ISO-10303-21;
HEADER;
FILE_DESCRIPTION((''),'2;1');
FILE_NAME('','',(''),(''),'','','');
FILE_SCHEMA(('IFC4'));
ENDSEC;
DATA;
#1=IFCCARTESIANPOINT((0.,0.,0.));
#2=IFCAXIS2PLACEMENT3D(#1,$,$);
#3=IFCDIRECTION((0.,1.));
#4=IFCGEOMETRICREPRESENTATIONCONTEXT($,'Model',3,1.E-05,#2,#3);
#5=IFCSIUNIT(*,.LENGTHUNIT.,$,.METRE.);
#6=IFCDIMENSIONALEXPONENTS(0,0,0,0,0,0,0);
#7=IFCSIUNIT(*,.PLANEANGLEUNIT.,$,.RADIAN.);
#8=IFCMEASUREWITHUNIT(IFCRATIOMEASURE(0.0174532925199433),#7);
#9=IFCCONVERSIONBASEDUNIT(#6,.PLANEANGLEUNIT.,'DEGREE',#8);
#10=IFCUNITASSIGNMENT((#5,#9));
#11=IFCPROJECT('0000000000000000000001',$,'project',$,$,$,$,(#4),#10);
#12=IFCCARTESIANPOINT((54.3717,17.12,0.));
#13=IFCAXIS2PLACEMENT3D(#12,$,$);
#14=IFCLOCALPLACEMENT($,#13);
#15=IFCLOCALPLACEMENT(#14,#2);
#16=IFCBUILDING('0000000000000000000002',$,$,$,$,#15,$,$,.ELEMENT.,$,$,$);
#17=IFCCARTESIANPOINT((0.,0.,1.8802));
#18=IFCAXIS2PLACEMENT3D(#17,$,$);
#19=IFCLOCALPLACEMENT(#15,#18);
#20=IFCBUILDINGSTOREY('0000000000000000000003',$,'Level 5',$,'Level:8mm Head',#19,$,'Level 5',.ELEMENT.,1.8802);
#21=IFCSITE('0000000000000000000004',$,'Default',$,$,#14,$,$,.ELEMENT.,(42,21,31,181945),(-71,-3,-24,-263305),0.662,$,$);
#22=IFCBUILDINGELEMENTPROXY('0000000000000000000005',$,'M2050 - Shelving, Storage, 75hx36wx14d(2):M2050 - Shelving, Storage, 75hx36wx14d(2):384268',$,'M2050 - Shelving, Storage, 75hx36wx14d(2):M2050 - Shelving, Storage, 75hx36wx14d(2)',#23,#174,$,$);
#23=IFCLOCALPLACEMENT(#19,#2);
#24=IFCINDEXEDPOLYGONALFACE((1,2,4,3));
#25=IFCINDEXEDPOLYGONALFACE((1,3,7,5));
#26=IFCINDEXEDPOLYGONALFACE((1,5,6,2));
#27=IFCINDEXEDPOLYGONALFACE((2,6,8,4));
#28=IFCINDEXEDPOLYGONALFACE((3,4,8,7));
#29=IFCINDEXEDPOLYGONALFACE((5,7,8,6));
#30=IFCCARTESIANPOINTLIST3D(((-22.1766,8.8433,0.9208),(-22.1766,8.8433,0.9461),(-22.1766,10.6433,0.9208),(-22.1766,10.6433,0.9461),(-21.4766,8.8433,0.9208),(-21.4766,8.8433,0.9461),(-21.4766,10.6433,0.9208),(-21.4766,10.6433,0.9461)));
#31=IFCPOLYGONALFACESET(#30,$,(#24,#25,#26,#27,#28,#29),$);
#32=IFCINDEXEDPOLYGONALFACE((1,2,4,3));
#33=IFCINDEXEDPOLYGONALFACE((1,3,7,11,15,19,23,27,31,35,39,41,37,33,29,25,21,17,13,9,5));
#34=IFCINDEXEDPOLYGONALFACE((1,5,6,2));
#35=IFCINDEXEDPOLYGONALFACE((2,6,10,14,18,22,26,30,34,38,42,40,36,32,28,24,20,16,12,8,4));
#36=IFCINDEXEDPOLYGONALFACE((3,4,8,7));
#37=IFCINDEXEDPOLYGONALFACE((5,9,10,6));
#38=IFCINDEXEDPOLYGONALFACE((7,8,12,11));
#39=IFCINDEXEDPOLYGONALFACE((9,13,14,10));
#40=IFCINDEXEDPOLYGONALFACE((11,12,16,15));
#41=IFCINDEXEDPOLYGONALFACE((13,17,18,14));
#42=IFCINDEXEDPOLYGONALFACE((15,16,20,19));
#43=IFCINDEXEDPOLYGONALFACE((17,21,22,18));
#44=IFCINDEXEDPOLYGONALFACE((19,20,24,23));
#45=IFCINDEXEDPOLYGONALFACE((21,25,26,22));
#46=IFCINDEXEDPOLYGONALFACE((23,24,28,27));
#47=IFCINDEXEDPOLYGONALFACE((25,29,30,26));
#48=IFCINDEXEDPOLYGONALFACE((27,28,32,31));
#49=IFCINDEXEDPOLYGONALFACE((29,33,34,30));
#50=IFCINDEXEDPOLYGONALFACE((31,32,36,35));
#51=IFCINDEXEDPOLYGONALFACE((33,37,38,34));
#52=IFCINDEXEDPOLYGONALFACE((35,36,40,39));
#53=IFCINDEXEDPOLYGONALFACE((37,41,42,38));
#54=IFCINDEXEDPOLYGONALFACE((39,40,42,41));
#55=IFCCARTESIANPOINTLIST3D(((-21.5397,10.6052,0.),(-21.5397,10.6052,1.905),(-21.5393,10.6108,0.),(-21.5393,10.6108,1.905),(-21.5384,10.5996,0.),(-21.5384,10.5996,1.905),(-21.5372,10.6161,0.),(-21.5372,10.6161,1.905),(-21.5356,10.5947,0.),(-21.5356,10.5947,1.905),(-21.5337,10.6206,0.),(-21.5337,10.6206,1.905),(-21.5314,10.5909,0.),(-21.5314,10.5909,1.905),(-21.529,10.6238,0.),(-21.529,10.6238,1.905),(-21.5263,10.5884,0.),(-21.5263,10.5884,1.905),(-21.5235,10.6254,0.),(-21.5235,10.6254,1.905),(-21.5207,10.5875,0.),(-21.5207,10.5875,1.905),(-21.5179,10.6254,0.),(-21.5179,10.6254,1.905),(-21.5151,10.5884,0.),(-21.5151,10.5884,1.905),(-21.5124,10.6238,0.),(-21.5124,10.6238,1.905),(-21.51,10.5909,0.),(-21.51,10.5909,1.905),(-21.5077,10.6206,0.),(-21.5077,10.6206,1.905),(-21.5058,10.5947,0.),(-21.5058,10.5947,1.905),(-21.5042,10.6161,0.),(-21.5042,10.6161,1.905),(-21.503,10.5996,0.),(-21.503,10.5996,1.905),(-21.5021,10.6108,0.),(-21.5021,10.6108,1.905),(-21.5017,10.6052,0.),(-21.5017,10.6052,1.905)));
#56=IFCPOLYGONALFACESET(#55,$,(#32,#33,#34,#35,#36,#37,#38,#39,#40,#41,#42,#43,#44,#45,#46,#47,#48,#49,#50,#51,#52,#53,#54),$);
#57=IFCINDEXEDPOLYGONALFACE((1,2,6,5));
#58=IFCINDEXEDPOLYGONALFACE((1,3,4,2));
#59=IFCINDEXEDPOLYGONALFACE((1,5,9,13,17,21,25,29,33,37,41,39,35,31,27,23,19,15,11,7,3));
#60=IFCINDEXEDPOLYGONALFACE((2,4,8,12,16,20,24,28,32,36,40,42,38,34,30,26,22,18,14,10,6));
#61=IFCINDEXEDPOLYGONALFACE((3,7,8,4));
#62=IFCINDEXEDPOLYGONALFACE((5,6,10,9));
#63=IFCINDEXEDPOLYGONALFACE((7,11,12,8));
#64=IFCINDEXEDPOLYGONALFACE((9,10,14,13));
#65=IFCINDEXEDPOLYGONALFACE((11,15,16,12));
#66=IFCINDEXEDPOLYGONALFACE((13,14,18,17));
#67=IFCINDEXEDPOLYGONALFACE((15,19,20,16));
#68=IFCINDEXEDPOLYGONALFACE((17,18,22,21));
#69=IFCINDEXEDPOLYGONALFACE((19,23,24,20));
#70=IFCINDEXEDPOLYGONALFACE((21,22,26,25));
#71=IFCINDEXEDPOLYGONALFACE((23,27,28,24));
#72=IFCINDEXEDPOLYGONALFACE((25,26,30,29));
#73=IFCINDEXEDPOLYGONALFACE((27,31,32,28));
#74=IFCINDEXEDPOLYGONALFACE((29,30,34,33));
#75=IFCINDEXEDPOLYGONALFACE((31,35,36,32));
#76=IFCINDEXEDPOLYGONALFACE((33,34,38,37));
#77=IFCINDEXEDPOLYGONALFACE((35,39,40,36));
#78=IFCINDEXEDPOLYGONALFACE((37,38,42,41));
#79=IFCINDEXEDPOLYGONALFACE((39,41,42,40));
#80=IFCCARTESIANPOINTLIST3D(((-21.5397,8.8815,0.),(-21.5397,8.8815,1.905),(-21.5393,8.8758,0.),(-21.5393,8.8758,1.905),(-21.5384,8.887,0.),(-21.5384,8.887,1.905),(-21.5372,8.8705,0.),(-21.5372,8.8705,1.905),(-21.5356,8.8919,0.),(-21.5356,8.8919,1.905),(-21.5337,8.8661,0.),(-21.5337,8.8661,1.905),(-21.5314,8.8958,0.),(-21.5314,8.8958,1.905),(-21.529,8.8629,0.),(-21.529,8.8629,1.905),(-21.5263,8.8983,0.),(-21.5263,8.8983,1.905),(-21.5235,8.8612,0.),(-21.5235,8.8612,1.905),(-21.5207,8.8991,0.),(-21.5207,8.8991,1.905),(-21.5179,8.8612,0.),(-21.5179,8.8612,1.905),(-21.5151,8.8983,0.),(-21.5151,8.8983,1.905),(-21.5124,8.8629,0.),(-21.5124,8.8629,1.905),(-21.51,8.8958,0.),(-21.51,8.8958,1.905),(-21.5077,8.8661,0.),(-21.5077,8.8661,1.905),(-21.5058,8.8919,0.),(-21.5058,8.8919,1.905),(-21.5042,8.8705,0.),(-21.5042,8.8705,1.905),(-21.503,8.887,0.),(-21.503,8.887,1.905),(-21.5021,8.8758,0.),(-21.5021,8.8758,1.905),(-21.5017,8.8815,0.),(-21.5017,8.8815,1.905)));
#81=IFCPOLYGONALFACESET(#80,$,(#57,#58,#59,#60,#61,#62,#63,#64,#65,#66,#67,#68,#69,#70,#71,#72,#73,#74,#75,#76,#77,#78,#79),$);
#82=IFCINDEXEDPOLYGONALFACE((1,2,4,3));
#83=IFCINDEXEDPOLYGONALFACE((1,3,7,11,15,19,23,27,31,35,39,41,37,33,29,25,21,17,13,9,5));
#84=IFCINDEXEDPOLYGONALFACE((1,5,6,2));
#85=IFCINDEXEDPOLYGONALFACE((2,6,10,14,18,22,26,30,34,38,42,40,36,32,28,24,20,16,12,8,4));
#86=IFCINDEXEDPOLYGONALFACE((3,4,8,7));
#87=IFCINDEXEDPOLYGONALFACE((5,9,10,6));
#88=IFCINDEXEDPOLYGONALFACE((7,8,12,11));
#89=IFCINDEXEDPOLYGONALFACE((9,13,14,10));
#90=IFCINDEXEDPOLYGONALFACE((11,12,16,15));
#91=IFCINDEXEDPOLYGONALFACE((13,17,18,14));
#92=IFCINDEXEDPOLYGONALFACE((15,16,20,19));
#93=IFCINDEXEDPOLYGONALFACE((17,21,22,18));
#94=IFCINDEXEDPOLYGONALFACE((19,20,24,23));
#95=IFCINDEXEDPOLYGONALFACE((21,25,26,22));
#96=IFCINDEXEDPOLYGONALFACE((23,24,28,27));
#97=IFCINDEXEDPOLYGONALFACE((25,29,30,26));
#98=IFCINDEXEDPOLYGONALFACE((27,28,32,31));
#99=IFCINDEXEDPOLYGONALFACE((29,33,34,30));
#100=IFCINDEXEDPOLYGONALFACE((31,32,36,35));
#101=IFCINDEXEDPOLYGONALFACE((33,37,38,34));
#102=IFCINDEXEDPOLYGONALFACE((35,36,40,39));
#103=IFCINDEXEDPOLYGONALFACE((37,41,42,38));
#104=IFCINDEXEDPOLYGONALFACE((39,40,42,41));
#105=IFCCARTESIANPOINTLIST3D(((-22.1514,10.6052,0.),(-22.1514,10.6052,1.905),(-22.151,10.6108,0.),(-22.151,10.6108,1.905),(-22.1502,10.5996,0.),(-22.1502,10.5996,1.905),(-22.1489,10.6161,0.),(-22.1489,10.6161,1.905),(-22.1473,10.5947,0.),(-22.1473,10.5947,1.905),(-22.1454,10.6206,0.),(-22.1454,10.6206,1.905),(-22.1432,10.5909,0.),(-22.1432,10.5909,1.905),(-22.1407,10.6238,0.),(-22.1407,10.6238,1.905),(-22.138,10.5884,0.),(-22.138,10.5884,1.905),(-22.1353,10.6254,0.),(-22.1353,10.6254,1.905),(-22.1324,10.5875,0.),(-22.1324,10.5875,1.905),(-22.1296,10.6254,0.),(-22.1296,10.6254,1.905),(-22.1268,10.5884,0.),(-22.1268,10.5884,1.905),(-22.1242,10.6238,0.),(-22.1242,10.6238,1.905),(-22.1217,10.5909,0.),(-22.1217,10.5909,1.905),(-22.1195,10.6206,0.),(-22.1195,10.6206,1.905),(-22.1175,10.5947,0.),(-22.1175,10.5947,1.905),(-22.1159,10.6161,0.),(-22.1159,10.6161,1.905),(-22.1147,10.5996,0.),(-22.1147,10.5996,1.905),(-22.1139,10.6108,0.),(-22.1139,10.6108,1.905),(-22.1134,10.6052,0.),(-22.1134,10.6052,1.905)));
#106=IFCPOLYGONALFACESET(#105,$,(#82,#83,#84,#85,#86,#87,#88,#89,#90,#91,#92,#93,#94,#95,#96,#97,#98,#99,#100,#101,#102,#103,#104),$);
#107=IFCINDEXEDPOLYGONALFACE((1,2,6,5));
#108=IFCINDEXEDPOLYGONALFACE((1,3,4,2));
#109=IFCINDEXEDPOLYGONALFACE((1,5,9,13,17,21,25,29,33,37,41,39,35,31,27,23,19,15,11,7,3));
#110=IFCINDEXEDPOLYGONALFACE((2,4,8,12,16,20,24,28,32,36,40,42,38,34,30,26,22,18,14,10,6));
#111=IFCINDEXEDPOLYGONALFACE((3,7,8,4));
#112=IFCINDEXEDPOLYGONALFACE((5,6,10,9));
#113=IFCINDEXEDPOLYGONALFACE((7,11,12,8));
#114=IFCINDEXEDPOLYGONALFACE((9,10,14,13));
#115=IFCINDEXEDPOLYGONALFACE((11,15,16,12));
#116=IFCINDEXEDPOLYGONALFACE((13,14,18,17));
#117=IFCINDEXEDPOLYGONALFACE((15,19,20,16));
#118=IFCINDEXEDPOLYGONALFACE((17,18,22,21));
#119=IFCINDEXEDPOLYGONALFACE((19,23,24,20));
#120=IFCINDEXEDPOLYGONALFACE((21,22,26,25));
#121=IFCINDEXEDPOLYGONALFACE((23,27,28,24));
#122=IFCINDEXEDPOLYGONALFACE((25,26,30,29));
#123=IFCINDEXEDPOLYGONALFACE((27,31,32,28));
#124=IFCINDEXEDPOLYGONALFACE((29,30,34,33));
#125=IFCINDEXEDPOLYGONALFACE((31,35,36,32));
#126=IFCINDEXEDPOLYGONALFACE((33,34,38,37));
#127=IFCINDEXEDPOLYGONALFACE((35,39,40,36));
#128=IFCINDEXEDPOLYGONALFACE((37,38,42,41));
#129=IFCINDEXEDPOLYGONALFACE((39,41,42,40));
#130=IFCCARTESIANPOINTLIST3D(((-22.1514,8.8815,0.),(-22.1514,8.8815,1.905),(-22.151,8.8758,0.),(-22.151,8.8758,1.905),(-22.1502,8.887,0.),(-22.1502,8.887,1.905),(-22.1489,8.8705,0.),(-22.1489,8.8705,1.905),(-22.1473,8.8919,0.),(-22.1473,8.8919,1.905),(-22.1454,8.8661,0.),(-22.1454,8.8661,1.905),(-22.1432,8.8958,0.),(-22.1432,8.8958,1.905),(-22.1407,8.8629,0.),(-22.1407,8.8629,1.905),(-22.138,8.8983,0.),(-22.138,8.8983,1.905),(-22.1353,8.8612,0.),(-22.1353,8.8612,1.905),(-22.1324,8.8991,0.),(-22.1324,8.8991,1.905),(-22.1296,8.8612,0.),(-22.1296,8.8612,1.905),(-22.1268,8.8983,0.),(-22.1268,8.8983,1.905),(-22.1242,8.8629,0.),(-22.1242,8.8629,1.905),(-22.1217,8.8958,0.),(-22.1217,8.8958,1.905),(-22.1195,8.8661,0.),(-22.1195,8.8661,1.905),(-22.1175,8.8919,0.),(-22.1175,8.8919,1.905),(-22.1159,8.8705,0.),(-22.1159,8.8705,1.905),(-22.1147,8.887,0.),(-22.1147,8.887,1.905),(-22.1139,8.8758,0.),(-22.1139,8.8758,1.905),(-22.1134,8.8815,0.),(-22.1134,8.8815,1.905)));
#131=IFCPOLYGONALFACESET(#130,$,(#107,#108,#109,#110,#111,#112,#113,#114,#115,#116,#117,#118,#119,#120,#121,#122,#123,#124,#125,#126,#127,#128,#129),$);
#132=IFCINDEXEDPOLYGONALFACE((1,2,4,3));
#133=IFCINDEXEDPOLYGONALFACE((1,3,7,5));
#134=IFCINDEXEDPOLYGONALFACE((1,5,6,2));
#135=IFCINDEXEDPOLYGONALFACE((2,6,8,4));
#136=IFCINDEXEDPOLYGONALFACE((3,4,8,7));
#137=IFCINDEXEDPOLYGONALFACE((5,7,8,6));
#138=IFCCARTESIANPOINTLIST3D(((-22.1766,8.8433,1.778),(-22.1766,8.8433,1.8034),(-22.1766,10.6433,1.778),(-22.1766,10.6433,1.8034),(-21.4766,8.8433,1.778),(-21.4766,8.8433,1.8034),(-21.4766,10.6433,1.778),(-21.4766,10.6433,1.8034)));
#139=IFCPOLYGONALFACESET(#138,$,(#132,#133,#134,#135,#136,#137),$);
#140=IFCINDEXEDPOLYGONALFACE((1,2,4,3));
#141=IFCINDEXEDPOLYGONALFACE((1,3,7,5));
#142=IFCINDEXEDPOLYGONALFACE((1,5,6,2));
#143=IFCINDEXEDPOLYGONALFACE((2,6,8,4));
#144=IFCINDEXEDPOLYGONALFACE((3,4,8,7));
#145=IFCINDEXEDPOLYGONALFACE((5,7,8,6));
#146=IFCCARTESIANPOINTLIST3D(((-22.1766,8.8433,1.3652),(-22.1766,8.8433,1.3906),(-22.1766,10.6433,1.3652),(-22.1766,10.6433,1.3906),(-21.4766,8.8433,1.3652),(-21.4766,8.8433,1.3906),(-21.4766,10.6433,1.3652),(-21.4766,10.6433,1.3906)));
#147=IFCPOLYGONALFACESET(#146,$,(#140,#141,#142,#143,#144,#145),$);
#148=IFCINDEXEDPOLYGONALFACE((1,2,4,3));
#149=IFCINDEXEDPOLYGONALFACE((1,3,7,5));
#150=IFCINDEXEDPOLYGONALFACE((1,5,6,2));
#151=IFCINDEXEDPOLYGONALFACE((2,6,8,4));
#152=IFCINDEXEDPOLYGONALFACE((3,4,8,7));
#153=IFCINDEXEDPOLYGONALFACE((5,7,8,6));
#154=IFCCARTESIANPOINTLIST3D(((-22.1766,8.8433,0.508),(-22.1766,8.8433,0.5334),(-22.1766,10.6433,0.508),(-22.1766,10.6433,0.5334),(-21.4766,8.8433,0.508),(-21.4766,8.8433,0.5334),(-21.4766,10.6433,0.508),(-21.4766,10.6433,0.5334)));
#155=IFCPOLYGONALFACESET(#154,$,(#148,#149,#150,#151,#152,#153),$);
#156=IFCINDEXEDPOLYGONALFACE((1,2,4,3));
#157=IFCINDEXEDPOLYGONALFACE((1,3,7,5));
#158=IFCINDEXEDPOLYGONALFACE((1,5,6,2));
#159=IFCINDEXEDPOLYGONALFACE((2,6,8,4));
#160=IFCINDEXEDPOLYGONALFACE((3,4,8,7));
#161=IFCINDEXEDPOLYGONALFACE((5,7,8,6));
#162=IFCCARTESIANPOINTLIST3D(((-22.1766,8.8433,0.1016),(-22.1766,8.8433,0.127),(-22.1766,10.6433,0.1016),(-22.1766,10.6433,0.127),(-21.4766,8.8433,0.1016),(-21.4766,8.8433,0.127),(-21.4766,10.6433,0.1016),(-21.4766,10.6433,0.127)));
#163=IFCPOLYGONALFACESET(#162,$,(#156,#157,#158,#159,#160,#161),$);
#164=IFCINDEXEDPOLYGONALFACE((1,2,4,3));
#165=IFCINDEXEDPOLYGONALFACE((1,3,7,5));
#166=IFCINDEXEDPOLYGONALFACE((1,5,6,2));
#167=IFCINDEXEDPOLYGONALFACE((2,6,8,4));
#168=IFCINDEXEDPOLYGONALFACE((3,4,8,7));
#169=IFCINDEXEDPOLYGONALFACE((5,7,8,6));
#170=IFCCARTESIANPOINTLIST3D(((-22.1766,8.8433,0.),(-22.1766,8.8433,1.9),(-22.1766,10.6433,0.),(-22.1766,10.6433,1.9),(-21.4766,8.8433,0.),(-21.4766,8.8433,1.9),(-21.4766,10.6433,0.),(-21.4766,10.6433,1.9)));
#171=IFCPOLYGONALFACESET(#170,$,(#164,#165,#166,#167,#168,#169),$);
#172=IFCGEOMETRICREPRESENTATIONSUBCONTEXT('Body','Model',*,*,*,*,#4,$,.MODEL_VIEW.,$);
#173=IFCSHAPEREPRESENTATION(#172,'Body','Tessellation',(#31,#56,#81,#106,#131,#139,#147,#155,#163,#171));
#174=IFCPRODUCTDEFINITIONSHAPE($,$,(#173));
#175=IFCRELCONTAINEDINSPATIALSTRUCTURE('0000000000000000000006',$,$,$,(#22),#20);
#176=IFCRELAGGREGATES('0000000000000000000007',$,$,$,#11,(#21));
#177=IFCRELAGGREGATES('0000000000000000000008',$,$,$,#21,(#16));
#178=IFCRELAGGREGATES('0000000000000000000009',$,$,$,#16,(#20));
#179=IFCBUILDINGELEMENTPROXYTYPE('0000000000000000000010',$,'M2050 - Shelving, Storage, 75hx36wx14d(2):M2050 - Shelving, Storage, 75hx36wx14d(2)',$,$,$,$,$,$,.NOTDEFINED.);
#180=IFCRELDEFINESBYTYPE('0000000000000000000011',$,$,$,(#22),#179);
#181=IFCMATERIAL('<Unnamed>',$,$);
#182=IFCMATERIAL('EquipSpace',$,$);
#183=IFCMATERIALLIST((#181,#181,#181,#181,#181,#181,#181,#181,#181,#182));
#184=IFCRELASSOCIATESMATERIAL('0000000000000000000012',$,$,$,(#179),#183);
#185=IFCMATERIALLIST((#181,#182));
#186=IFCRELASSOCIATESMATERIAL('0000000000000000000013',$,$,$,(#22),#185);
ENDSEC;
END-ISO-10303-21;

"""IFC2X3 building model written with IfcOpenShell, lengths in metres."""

from ifc_helpers import new_model, entity, si_unit, converted_unit, direction, frame, frame_2d, origin, origin_2d_with_axis, place, context, subcontext, project, spatial, rectangle, circle, extrude, source, transform, mapped, material, material_list, type_object, type_shapes, element, save


model = new_model("IFC2X3")

# Units and contexts
model_context = context("Model", 3, precision=1e-05, world=origin(), true_north=direction((0.0, 1.0)))
body_context = subcontext(model_context, "Body", "Model", "MODEL_VIEW")
ifc_project = project(units=[si_unit("LENGTHUNIT", "METRE"), converted_unit("PLANEANGLEUNIT", "DEGREE", entity("IfcRatioMeasure", 0.0174532925199433), si_unit("PLANEANGLEUNIT", "RADIAN"), dimensions=[0, 0, 0, 0, 0, 0, 0])], contexts=[model_context])

# Site, building, storey
site_placement = place(None, frame((54.3717, 17.12, 0.0)))
site = spatial("IfcSite", under=ifc_project, at=site_placement, Name="Default", CompositionType="ELEMENT", RefLatitude=(42, 21, 31, 181945), RefLongitude=(-71, -3, -24, -263305), RefElevation=0.662)
building_placement = place(site_placement, origin())
building = spatial("IfcBuilding", under=site, at=building_placement, CompositionType="ELEMENT")
storey_placement = place(building_placement, frame((0.0, 0.0, 1.8802)))
storey = spatial("IfcBuildingStorey", under=building, at=storey_placement, Name="Level 5", ObjectType="Level:8mm Head", LongName="Level 5", CompositionType="ELEMENT", Elevation=1.8802)

# Building element proxy
ifc_material_1 = material(Name="<Unnamed>")
ifc_material_2 = material(Name="EquipSpace")
ifc_material_list_1 = material_list([ifc_material_1, ifc_material_1, ifc_material_1, ifc_material_1, ifc_material_1, ifc_material_1, ifc_material_1, ifc_material_1, ifc_material_1, ifc_material_2])
building_element_proxy_type = type_object("IfcBuildingElementProxyType", Name="M2050 - Shelving, Storage, 75hx36wx14d(2):M2050 - Shelving, Storage, 75hx36wx14d(2)", PredefinedType="NOTDEFINED", material=ifc_material_list_1)
shared_shape = source(origin(), body_context, "Body", "SweptSolid", [
    extrude(rectangle(XDim=1.8, YDim=0.7, at=origin_2d_with_axis()), frame((0.0, 0.0, 0.9207), z_axis=(0.0, 0.0, 1.0), x_axis=(-1.0, 0.0, 0.0)), (0.0, 0.0, 1.0), 0.0254),
    extrude(circle(Radius=0.0191, at=origin_2d_with_axis()), frame((0.8633, -0.3059, 0.0), z_axis=(0.0, 0.0, 1.0), x_axis=(-1.0, 0.0, 0.0)), (0.0, 0.0, 1.0), 1.905),
    extrude(circle(Radius=0.0191, at=origin_2d_with_axis()), frame((-0.8633, -0.3059, 0.0)), (0.0, 0.0, 1.0), 1.905),
    extrude(circle(Radius=0.0191, at=origin_2d_with_axis()), frame((0.8633, 0.3059, 0.0), z_axis=(0.0, 0.0, 1.0), x_axis=(-1.0, 0.0, 0.0)), (0.0, 0.0, 1.0), 1.905),
    extrude(circle(Radius=0.0191, at=origin_2d_with_axis()), frame((-0.8633, 0.3059, 0.0)), (0.0, 0.0, 1.0), 1.905),
    extrude(rectangle(XDim=1.8, YDim=0.7, at=origin_2d_with_axis()), frame((0.0, 0.0, 1.778), z_axis=(0.0, 0.0, 1.0), x_axis=(-1.0, 0.0, 0.0)), (0.0, 0.0, 1.0), 0.0254),
    extrude(rectangle(XDim=1.8, YDim=0.7, at=origin_2d_with_axis()), frame((0.0, 0.0, 1.3653), z_axis=(0.0, 0.0, 1.0), x_axis=(-1.0, 0.0, 0.0)), (0.0, 0.0, 1.0), 0.0254),
    extrude(rectangle(XDim=1.8, YDim=0.7, at=origin_2d_with_axis()), frame((0.0, 0.0, 0.508), z_axis=(0.0, 0.0, 1.0), x_axis=(-1.0, 0.0, 0.0)), (0.0, 0.0, 1.0), 0.0254),
    extrude(rectangle(XDim=1.8, YDim=0.7, at=origin_2d_with_axis()), frame((0.0, 0.0, 0.1016), z_axis=(0.0, 0.0, 1.0), x_axis=(-1.0, 0.0, 0.0)), (0.0, 0.0, 1.0), 0.0254),
    extrude(rectangle(XDim=0.7, YDim=1.8, at=frame_2d((0.0, 0.18), x_axis=(1.0, 0.0))), frame((-0.18, 0.0, 0.0), z_axis=(0.0, 0.0, 1.0), x_axis=(0.0, -1.0, 0.0)), (0.0, 0.0, 1.0), 1.9),
])
type_shapes(building_element_proxy_type, [shared_shape])
ifc_material_list_2 = material_list([ifc_material_1, ifc_material_2])
proxy_1_placement = place(storey_placement, frame((-21.8266, 9.7433, 0.0), z_axis=(0.0, 0.0, 1.0), x_axis=(0.0, 1.0, 0.0)))
element("IfcBuildingElementProxy", 1, at=proxy_1_placement, inside=storey, type_object=building_element_proxy_type, material=ifc_material_list_2, Name="M2050 - Shelving, Storage, 75hx36wx14d(2):M2050 - Shelving, Storage, 75hx36wx14d(2):384268", ObjectType="M2050 - Shelving, Storage, 75hx36wx14d(2):M2050 - Shelving, Storage, 75hx36wx14d(2)", context=body_context, shape_type="MappedRepresentation", body=[
    mapped(shared_shape, transform((0.0, 0.0, 0.0), scale=1.0)),
])

save(model, "model.ifc")
